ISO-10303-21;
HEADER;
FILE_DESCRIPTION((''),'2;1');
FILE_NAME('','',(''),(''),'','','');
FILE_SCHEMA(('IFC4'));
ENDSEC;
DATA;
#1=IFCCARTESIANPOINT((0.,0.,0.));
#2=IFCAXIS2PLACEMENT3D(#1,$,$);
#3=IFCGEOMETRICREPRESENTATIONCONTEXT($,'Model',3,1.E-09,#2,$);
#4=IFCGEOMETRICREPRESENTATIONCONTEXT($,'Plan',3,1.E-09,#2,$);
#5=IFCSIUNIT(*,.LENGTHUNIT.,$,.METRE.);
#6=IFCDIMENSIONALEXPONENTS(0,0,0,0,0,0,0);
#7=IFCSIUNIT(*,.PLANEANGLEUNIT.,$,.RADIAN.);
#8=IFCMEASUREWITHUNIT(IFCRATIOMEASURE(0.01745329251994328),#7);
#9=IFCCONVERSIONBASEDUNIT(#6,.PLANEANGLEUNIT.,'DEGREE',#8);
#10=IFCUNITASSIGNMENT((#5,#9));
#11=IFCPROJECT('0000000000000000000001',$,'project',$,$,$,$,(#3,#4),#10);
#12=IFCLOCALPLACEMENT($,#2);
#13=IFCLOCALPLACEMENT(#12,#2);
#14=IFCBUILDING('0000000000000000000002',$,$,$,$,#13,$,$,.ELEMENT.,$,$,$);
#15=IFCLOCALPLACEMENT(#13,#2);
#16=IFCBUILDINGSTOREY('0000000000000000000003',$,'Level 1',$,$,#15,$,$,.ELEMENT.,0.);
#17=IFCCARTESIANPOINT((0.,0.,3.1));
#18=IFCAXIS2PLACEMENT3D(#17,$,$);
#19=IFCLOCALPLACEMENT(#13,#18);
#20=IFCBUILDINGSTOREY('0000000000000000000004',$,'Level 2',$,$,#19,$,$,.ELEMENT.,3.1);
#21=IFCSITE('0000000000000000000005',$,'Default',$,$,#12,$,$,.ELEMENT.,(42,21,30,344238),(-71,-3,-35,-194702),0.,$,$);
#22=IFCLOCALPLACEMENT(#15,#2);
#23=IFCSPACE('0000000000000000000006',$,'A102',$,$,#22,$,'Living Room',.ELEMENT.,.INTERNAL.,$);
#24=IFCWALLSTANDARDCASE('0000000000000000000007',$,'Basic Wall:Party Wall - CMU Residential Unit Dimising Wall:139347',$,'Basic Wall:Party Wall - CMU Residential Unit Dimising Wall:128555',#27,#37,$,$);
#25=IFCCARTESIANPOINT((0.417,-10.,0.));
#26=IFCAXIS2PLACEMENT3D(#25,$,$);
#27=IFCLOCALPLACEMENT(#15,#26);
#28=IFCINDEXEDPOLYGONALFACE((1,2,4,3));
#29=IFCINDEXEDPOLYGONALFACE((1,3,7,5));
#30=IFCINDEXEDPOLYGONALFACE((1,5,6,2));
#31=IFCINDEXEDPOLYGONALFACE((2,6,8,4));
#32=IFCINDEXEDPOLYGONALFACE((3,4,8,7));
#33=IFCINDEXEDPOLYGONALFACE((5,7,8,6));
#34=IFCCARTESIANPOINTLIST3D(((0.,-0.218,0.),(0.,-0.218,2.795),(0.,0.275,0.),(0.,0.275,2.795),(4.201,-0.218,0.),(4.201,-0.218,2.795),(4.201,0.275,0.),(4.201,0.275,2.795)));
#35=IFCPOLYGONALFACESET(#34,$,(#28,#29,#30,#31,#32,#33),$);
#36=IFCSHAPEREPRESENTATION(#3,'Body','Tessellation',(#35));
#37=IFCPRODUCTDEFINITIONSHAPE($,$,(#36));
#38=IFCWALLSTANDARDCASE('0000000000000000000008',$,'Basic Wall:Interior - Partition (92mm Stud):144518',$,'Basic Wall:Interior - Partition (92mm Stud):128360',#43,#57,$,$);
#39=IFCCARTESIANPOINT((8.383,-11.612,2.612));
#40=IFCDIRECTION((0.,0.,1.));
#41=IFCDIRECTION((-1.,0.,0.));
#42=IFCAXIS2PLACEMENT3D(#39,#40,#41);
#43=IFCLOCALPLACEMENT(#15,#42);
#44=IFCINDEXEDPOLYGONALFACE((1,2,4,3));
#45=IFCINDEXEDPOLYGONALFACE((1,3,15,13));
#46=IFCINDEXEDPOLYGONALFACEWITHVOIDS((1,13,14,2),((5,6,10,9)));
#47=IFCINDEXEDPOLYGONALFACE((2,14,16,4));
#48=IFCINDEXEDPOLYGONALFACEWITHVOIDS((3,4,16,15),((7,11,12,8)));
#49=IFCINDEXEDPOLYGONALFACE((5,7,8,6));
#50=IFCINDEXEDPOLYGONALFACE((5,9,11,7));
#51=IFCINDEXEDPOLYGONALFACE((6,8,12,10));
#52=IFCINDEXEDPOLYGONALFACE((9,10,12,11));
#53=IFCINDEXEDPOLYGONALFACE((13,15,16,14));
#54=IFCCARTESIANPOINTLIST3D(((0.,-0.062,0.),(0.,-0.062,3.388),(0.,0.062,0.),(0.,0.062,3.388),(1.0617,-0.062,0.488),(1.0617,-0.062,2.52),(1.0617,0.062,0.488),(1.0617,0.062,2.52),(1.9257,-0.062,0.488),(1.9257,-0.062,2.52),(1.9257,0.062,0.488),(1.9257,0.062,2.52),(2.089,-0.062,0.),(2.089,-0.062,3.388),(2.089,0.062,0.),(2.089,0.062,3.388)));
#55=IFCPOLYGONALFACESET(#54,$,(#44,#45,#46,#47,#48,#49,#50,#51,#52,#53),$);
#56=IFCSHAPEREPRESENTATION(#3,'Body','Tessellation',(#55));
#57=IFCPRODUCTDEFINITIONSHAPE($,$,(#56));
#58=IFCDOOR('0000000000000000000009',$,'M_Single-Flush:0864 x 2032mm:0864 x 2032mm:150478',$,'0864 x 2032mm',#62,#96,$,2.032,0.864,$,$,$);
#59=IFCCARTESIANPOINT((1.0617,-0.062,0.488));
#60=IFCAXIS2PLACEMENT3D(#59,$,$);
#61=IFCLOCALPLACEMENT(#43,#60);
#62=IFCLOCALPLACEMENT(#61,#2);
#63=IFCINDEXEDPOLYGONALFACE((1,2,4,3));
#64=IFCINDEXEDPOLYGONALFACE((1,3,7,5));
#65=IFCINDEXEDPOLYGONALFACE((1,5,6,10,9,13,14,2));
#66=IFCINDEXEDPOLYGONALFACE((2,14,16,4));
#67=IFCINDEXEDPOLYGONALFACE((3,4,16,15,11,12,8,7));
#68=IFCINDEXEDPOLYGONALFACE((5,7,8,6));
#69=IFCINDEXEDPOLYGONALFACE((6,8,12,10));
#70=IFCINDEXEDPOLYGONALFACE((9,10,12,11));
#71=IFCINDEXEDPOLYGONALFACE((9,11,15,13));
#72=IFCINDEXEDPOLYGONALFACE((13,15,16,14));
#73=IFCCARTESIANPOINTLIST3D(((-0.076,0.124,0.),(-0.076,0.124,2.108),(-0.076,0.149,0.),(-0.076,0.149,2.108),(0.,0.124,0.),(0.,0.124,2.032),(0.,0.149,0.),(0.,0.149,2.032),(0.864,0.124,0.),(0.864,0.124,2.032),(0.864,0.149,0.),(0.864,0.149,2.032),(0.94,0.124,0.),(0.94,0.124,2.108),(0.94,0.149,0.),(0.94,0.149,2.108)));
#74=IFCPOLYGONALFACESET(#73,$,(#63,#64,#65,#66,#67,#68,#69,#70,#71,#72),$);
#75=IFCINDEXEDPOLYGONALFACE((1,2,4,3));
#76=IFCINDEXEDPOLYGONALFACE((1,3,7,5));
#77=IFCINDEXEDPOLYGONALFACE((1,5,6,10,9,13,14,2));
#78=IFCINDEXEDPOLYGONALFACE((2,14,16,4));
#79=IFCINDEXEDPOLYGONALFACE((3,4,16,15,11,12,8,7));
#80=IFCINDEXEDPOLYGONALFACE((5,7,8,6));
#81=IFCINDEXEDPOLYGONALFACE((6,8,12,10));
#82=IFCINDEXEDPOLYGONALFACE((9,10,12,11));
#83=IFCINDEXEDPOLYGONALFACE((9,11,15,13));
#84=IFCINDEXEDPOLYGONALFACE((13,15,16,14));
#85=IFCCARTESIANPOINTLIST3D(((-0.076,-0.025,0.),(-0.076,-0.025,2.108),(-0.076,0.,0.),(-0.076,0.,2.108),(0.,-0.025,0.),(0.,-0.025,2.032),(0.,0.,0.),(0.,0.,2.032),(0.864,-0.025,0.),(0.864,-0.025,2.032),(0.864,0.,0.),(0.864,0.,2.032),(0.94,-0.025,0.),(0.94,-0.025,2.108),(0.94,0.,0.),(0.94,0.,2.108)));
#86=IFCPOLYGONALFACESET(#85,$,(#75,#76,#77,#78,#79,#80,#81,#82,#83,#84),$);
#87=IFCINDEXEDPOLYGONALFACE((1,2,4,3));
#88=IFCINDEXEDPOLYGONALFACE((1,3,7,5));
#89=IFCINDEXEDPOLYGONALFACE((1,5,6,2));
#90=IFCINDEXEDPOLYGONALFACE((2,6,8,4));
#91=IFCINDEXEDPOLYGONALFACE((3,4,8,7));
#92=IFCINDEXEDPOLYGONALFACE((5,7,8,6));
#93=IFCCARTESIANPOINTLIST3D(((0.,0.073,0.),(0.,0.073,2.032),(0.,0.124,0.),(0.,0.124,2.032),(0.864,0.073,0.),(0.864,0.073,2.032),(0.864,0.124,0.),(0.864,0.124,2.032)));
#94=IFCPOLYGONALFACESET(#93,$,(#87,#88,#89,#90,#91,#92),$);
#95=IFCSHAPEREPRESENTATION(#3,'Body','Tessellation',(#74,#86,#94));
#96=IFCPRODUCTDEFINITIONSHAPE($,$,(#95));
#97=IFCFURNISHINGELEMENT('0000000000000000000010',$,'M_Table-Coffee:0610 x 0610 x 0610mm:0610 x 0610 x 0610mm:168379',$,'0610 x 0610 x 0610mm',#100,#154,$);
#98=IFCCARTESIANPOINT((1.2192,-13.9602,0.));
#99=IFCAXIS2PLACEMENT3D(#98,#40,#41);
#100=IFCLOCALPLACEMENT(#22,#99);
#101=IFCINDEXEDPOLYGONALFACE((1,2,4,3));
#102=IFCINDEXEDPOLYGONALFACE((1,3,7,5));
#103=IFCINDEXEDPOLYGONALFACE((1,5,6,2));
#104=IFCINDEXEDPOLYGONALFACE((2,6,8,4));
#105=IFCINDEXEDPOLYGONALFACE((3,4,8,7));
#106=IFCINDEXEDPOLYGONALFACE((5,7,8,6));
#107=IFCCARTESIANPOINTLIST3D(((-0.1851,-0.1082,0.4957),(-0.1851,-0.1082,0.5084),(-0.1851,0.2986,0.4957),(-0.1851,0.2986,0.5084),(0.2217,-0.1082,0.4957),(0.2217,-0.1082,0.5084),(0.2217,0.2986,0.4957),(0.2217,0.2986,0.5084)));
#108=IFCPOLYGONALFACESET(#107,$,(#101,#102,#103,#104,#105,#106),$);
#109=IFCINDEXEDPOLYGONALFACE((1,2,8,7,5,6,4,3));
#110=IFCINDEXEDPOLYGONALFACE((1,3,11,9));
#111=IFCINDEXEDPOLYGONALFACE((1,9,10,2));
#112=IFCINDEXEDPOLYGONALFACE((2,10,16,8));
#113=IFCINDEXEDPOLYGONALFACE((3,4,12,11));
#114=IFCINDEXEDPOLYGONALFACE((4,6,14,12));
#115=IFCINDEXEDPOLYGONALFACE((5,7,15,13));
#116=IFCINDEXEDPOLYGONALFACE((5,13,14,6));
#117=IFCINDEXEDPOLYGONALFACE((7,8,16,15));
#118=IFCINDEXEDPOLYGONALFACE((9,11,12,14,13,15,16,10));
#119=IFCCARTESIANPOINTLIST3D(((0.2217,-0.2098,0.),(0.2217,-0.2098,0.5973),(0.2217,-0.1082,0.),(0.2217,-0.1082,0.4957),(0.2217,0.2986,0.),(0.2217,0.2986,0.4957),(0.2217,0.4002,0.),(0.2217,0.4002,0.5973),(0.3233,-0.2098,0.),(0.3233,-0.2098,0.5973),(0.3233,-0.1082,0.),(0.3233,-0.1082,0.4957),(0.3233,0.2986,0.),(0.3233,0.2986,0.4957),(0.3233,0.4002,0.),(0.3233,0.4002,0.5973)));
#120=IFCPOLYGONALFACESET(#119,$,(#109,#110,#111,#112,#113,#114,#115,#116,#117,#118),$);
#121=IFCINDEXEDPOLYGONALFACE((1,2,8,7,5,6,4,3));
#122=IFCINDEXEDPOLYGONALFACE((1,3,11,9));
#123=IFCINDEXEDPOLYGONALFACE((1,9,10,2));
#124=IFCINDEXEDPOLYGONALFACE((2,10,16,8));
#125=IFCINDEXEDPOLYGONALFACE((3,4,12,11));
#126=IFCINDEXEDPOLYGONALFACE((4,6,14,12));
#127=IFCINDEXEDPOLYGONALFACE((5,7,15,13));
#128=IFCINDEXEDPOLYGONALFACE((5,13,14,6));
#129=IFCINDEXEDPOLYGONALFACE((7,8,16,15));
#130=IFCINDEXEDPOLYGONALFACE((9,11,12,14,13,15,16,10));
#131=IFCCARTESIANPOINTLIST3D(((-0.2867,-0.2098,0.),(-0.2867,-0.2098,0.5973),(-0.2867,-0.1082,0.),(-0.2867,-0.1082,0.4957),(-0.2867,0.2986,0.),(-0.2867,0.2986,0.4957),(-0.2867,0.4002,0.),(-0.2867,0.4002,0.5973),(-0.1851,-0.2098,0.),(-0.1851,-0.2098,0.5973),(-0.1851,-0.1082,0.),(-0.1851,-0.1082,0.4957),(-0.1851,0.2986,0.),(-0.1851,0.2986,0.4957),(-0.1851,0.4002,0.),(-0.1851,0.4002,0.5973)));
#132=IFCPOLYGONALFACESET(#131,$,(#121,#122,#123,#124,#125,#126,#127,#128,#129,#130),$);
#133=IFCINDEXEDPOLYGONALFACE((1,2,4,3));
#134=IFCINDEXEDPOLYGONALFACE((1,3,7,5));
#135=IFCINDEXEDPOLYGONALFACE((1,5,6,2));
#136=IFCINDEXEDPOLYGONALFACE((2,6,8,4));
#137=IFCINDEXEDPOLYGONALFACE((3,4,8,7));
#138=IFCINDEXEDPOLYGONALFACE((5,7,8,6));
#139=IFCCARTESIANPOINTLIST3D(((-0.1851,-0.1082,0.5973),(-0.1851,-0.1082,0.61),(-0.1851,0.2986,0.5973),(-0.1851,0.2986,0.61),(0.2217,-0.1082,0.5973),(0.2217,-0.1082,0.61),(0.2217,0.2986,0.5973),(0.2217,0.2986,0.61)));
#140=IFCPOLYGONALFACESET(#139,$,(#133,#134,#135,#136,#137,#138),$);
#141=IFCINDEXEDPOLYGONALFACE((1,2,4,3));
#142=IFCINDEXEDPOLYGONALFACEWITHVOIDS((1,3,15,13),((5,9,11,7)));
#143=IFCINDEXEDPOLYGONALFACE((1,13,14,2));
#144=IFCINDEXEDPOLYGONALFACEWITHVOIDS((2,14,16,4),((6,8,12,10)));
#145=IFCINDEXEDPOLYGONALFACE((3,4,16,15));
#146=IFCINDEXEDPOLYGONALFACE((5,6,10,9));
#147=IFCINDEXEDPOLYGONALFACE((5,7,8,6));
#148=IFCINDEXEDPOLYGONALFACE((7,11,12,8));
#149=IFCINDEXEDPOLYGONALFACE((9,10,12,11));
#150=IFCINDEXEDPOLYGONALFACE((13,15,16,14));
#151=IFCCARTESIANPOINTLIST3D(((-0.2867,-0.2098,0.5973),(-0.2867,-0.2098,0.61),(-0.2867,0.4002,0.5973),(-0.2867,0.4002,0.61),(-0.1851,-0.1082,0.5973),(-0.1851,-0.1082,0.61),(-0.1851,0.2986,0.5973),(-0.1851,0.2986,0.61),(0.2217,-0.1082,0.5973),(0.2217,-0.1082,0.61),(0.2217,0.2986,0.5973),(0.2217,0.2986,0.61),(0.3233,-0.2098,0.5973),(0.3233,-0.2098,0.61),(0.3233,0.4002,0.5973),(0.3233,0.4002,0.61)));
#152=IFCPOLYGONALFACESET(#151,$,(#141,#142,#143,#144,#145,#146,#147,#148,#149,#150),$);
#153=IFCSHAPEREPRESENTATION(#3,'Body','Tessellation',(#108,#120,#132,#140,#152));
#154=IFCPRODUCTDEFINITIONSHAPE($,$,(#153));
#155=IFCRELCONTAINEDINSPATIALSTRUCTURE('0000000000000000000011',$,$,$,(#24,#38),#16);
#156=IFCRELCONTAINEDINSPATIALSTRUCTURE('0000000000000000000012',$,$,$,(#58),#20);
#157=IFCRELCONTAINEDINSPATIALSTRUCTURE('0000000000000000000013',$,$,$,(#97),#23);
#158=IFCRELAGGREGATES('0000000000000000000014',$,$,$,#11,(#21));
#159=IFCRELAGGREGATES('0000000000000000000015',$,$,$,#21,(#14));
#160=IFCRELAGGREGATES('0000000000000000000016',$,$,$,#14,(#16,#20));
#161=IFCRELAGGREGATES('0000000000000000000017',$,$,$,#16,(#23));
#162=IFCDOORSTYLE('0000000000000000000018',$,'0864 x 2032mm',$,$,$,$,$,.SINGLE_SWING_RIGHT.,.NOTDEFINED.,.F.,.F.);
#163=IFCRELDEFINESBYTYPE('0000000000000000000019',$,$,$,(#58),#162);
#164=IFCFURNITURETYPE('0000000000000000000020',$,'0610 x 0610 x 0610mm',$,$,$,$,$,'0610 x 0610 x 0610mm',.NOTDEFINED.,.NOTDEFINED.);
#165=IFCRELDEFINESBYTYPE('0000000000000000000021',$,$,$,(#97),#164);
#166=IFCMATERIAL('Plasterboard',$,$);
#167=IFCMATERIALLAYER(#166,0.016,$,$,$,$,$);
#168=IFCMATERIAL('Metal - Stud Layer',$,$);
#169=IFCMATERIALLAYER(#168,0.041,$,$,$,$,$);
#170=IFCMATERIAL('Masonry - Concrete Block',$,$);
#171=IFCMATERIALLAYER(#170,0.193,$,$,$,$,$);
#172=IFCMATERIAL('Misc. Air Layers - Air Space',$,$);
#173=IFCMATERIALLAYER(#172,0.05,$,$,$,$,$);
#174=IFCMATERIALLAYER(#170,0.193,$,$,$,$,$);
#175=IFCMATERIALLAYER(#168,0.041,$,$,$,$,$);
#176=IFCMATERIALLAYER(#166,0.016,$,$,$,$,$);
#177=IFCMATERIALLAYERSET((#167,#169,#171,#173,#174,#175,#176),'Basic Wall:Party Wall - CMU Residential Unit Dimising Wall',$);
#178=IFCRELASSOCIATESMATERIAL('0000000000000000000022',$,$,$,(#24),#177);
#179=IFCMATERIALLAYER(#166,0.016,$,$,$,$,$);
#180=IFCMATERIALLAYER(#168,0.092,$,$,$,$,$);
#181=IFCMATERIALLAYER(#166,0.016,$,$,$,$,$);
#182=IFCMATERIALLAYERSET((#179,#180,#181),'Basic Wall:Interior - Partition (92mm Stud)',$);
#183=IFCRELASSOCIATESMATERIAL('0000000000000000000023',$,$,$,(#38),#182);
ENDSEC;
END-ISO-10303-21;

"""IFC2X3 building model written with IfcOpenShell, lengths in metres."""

from ifc_helpers import new_model, entity, si_unit, converted_unit, frame, frame_2d, origin, origin_2d_with_axis, place, context, project, spatial, polyline, rectangle, outline, extrude, clip, bounded_halfspace, source, transform, mapped, material, layer, layer_set, layer_usage, type_object, type_shapes, element, fill, save


model = new_model("IFC2X3")

# Units and contexts
model_context = context("Model", 3, precision=1e-09, world=origin())
plan_context = context("Plan", 3, precision=1e-09, world=origin())
ifc_project = project(units=[si_unit("LENGTHUNIT", "METRE"), converted_unit("PLANEANGLEUNIT", "DEGREE", entity("IfcRatioMeasure", 0.01745329251994328), si_unit("PLANEANGLEUNIT", "RADIAN"), dimensions=[0, 0, 0, 0, 0, 0, 0])], contexts=[model_context, plan_context])

# Site, building, storey
site_placement = place(None, origin())
site = spatial("IfcSite", under=ifc_project, at=site_placement, Name="Default", CompositionType="ELEMENT", RefLatitude=(42, 21, 30, 344238), RefLongitude=(-71, -3, -35, -194702), RefElevation=0.0)
building_placement = place(site_placement, origin())
building = spatial("IfcBuilding", under=site, at=building_placement, CompositionType="ELEMENT")
storey_1_placement = place(building_placement, origin())
storey_1 = spatial("IfcBuildingStorey", under=building, at=storey_1_placement, Name="Level 1", CompositionType="ELEMENT", Elevation=0.0)

# Shared definitions
ifc_material_1 = material(Name="Misc. Air Layers - Air Space")
ifc_material_2 = material(Name="Masonry - Concrete Block")
ifc_material_3 = material(Name="Metal - Stud Layer")
ifc_material_4 = material(Name="Plasterboard")

# Wall
ifc_layer_1 = layer(ifc_material_4, 0.016)
ifc_layer_2 = layer(ifc_material_3, 0.041)
ifc_layer_3 = layer(ifc_material_2, 0.193)
ifc_layer_4 = layer(ifc_material_1, 0.05)
ifc_layer_5 = layer(ifc_material_2, 0.193)
ifc_layer_6 = layer(ifc_material_3, 0.041)
ifc_layer_7 = layer(ifc_material_4, 0.016)
ifc_layer_set_1 = layer_set([ifc_layer_1, ifc_layer_2, ifc_layer_3, ifc_layer_4, ifc_layer_5, ifc_layer_6, ifc_layer_7], Name="Basic Wall:Party Wall - CMU Residential Unit Dimising Wall")
ifc_layer_usage_1 = layer_usage(ifc_layer_set_1, "AXIS2", "NEGATIVE", 0.275)
wall_1_placement = place(storey_1_placement, frame((0.417, -10.0, 0.0)))
element("IfcWallStandardCase", 1, at=wall_1_placement, inside=storey_1, material=ifc_layer_usage_1, Name="Basic Wall:Party Wall - CMU Residential Unit Dimising Wall:139347", ObjectType="Basic Wall:Party Wall - CMU Residential Unit Dimising Wall:128555", context=model_context, shape_type="Clipping", body=[
    clip(clip(extrude(rectangle(XDim=4.201, YDim=0.55, at=frame_2d((2.1005, 0.0), x_axis=(-1.0, 0.0))), origin(), (0.0, 0.0, 1.0), 2.795), bounded_halfspace(frame((0.0, -0.218, 0.0), z_axis=(0.0, 1.0, 0.0), x_axis=(-1.0, 0.0, 0.0)), True, frame((0.0, -0.218, 0.0), z_axis=(0.0, 1.0, 0.0), x_axis=(-1.0, 0.0, 0.0)), polyline([(0.0, 0.0), (0.0, 2.795), (-4.201, 2.795), (-4.201, 0.0), (0.0, 0.0)]))), bounded_halfspace(frame((4.201, 0.275, 0.0), z_axis=(-1.0, 0.0, 0.0), x_axis=(0.0, -1.0, 0.0)), True, frame((4.201, 0.275, 0.0), z_axis=(-1.0, 0.0, 0.0), x_axis=(0.0, -1.0, 0.0)), polyline([(0.0, 0.0), (0.493, 0.0), (0.493, 2.795), (0.0, 2.795), (0.0, 0.0)]))),
])

# Shared definitions
ifc_layer_8 = layer(ifc_material_4, 0.016)
ifc_layer_9 = layer(ifc_material_3, 0.092)
ifc_layer_10 = layer(ifc_material_4, 0.016)
ifc_layer_set_2 = layer_set([ifc_layer_8, ifc_layer_9, ifc_layer_10], Name="Basic Wall:Interior - Partition (92mm Stud)")

# Wall, opening
ifc_layer_usage_2 = layer_usage(ifc_layer_set_2, "AXIS2", "NEGATIVE", 0.062)
wall_2_placement = place(storey_1_placement, frame((8.383, -11.612, 2.612), z_axis=(0.0, 0.0, 1.0), x_axis=(-1.0, 0.0, 0.0)))
wall_2 = element("IfcWallStandardCase", 2, at=wall_2_placement, inside=storey_1, material=ifc_layer_usage_2, Name="Basic Wall:Interior - Partition (92mm Stud):144518", ObjectType="Basic Wall:Interior - Partition (92mm Stud):128360", context=model_context, shape_type="SweptSolid", body=[
    extrude(rectangle(XDim=2.089, YDim=0.124, at=frame_2d((1.0445, 0.0), x_axis=(-1.0, 0.0))), origin(), (0.0, 0.0, 1.0), 3.388),
])
opening_1_placement = place(wall_2_placement, frame((1.0617, -0.062, 0.488)))
opening_1 = element("IfcOpeningElement", 3, at=opening_1_placement, cuts=wall_2, ObjectType="Opening", context=model_context, shape_type="SweptSolid", body=[
    extrude(rectangle(XDim=0.864, YDim=2.032, at=frame_2d((1.016, 0.432), x_axis=(0.0, 1.0))), frame((0.0, 0.0, 0.0), z_axis=(0.0, 1.0, 0.0), x_axis=(0.0, 0.0, 1.0)), (0.0, 0.0, 1.0), 0.124),
])

# Shared definitions
storey_2_placement = place(building_placement, frame((0.0, 0.0, 3.1)))
storey_2 = spatial("IfcBuildingStorey", under=building, at=storey_2_placement, Name="Level 2", CompositionType="ELEMENT", Elevation=3.1)

# Door
door_style_1 = type_object("IfcDoorStyle", Name="0864 x 2032mm", ConstructionType="NOTDEFINED", OperationType="SINGLE_SWING_RIGHT", ParameterTakesPrecedence=False, Sizeable=False)
shared_shape_1 = source(origin(), model_context, "Body", "SweptSolid", [
    extrude(outline(polyline([(-0.508, -1.073), (0.508, -1.073), (0.508, 1.035), (0.432, 1.035), (0.432, -0.997), (-0.432, -0.997), (-0.432, 1.035), (-0.508, 1.035), (-0.508, -1.073)])), frame((0.432, 0.124, 1.035), z_axis=(0.0, 1.0, 0.0), x_axis=(1.0, 0.0, 0.0)), (0.0, 0.0, 1.0), 0.025),
    extrude(outline(polyline([(-1.073, -0.508), (1.035, -0.508), (1.035, -0.432), (-0.997, -0.432), (-0.997, 0.432), (1.035, 0.432), (1.035, 0.508), (-1.073, 0.508), (-1.073, -0.508)])), frame((0.432, -0.025, 1.035), z_axis=(0.0, 1.0, 0.0), x_axis=(0.0, 0.0, -1.0)), (0.0, 0.0, 1.0), 0.025),
    extrude(rectangle(XDim=0.051, YDim=0.864, at=origin_2d_with_axis()), frame((0.432, 0.0985, 0.0), z_axis=(0.0, 0.0, 1.0), x_axis=(0.0, 1.0, 0.0)), (0.0, 0.0, 1.0), 2.032),
])
type_shapes(door_style_1, [shared_shape_1])
door_1_placement = place(opening_1_placement, origin())
door_1 = element("IfcDoor", 4, at=door_1_placement, inside=storey_2, type_object=door_style_1, Name="M_Single-Flush:0864 x 2032mm:0864 x 2032mm:150478", ObjectType="0864 x 2032mm", OverallHeight=2.032, OverallWidth=0.864, context=model_context, shape_type="MappedRepresentation", body=[
    mapped(shared_shape_1, transform((0.0, 0.0, 0.0), scale=1.0)),
])
fill(opening_1, door_1)

# Shared definitions
space_1_placement = place(storey_1_placement, origin())
space_1 = spatial("IfcSpace", under=storey_1, at=space_1_placement, Name="A102", LongName="Living Room", CompositionType="ELEMENT", InteriorOrExteriorSpace="INTERNAL")

# Furnishing element
furniture_type_1 = type_object("IfcFurnitureType", Name="0610 x 0610 x 0610mm", ElementType="0610 x 0610 x 0610mm", AssemblyPlace="NOTDEFINED")
shared_shape_2 = source(origin(), model_context, "Body", "SweptSolid", [
    extrude(rectangle(XDim=0.4068, YDim=0.4068, at=origin_2d_with_axis()), frame((0.0183, 0.0952, 0.4957), z_axis=(0.0, 0.0, 1.0), x_axis=(-1.0, 0.0, 0.0)), (0.0, 0.0, 1.0), 0.0127),
    extrude(outline(polyline([(-0.2732, -0.305), (0.324, -0.305), (0.324, 0.305), (-0.2732, 0.305), (-0.2732, 0.2034), (0.2225, 0.2034), (0.2225, -0.2034), (-0.2732, -0.2034), (-0.2732, -0.305)])), frame((0.2217, 0.0952, 0.2732), z_axis=(1.0, 0.0, 0.0), x_axis=(0.0, 0.0, 1.0)), (0.0, 0.0, 1.0), 0.1016),
    extrude(outline(polyline([(-0.305, -0.3241), (0.305, -0.3241), (0.305, 0.2733), (0.2034, 0.2733), (0.2034, -0.2224), (-0.2034, -0.2224), (-0.2034, 0.2733), (-0.305, 0.2733), (-0.305, -0.3241)])), frame((-0.2867, 0.0952, 0.2733), z_axis=(1.0, 0.0, 0.0), x_axis=(0.0, -1.0, 0.0)), (0.0, 0.0, 1.0), 0.1016),
    extrude(rectangle(XDim=0.4068, YDim=0.4068, at=origin_2d_with_axis()), frame((0.0183, 0.0952, 0.5973), z_axis=(0.0, 0.0, 1.0), x_axis=(-1.0, 0.0, 0.0)), (0.0, 0.0, 1.0), 0.0127),
    extrude(outline(polyline([(-0.305, -0.305), (0.305, -0.305), (0.305, 0.305), (-0.305, 0.305), (-0.305, -0.305)]), holes=[polyline([(-0.2034, -0.2034), (-0.2034, 0.2034), (0.2034, 0.2034), (0.2034, -0.2034), (-0.2034, -0.2034)])]), frame((0.0183, 0.0952, 0.5973), z_axis=(0.0, 0.0, 1.0), x_axis=(-1.0, 0.0, 0.0)), (0.0, 0.0, 1.0), 0.0127),
])
type_shapes(furniture_type_1, [shared_shape_2])
for number, where, z_axis, x_axis, name in (
    (5, (1.2192, -13.9602, 0.0), (0.0, 0.0, 1.0), (-1.0, 0.0, 0.0), "M_Table-Coffee:0610 x 0610 x 0610mm:0610 x 0610 x 0610mm:168379"),
):
    element("IfcFurnishingElement", number, at=place(space_1_placement, frame(where, z_axis=z_axis, x_axis=x_axis)), inside=space_1, type_object=furniture_type_1, Name=name, ObjectType="0610 x 0610 x 0610mm", context=model_context, shape_type="MappedRepresentation", body=[
        mapped(shared_shape_2, transform((0.0, 0.0, 0.0), scale=1.0)),
    ])

save(model, "model.ifc")
